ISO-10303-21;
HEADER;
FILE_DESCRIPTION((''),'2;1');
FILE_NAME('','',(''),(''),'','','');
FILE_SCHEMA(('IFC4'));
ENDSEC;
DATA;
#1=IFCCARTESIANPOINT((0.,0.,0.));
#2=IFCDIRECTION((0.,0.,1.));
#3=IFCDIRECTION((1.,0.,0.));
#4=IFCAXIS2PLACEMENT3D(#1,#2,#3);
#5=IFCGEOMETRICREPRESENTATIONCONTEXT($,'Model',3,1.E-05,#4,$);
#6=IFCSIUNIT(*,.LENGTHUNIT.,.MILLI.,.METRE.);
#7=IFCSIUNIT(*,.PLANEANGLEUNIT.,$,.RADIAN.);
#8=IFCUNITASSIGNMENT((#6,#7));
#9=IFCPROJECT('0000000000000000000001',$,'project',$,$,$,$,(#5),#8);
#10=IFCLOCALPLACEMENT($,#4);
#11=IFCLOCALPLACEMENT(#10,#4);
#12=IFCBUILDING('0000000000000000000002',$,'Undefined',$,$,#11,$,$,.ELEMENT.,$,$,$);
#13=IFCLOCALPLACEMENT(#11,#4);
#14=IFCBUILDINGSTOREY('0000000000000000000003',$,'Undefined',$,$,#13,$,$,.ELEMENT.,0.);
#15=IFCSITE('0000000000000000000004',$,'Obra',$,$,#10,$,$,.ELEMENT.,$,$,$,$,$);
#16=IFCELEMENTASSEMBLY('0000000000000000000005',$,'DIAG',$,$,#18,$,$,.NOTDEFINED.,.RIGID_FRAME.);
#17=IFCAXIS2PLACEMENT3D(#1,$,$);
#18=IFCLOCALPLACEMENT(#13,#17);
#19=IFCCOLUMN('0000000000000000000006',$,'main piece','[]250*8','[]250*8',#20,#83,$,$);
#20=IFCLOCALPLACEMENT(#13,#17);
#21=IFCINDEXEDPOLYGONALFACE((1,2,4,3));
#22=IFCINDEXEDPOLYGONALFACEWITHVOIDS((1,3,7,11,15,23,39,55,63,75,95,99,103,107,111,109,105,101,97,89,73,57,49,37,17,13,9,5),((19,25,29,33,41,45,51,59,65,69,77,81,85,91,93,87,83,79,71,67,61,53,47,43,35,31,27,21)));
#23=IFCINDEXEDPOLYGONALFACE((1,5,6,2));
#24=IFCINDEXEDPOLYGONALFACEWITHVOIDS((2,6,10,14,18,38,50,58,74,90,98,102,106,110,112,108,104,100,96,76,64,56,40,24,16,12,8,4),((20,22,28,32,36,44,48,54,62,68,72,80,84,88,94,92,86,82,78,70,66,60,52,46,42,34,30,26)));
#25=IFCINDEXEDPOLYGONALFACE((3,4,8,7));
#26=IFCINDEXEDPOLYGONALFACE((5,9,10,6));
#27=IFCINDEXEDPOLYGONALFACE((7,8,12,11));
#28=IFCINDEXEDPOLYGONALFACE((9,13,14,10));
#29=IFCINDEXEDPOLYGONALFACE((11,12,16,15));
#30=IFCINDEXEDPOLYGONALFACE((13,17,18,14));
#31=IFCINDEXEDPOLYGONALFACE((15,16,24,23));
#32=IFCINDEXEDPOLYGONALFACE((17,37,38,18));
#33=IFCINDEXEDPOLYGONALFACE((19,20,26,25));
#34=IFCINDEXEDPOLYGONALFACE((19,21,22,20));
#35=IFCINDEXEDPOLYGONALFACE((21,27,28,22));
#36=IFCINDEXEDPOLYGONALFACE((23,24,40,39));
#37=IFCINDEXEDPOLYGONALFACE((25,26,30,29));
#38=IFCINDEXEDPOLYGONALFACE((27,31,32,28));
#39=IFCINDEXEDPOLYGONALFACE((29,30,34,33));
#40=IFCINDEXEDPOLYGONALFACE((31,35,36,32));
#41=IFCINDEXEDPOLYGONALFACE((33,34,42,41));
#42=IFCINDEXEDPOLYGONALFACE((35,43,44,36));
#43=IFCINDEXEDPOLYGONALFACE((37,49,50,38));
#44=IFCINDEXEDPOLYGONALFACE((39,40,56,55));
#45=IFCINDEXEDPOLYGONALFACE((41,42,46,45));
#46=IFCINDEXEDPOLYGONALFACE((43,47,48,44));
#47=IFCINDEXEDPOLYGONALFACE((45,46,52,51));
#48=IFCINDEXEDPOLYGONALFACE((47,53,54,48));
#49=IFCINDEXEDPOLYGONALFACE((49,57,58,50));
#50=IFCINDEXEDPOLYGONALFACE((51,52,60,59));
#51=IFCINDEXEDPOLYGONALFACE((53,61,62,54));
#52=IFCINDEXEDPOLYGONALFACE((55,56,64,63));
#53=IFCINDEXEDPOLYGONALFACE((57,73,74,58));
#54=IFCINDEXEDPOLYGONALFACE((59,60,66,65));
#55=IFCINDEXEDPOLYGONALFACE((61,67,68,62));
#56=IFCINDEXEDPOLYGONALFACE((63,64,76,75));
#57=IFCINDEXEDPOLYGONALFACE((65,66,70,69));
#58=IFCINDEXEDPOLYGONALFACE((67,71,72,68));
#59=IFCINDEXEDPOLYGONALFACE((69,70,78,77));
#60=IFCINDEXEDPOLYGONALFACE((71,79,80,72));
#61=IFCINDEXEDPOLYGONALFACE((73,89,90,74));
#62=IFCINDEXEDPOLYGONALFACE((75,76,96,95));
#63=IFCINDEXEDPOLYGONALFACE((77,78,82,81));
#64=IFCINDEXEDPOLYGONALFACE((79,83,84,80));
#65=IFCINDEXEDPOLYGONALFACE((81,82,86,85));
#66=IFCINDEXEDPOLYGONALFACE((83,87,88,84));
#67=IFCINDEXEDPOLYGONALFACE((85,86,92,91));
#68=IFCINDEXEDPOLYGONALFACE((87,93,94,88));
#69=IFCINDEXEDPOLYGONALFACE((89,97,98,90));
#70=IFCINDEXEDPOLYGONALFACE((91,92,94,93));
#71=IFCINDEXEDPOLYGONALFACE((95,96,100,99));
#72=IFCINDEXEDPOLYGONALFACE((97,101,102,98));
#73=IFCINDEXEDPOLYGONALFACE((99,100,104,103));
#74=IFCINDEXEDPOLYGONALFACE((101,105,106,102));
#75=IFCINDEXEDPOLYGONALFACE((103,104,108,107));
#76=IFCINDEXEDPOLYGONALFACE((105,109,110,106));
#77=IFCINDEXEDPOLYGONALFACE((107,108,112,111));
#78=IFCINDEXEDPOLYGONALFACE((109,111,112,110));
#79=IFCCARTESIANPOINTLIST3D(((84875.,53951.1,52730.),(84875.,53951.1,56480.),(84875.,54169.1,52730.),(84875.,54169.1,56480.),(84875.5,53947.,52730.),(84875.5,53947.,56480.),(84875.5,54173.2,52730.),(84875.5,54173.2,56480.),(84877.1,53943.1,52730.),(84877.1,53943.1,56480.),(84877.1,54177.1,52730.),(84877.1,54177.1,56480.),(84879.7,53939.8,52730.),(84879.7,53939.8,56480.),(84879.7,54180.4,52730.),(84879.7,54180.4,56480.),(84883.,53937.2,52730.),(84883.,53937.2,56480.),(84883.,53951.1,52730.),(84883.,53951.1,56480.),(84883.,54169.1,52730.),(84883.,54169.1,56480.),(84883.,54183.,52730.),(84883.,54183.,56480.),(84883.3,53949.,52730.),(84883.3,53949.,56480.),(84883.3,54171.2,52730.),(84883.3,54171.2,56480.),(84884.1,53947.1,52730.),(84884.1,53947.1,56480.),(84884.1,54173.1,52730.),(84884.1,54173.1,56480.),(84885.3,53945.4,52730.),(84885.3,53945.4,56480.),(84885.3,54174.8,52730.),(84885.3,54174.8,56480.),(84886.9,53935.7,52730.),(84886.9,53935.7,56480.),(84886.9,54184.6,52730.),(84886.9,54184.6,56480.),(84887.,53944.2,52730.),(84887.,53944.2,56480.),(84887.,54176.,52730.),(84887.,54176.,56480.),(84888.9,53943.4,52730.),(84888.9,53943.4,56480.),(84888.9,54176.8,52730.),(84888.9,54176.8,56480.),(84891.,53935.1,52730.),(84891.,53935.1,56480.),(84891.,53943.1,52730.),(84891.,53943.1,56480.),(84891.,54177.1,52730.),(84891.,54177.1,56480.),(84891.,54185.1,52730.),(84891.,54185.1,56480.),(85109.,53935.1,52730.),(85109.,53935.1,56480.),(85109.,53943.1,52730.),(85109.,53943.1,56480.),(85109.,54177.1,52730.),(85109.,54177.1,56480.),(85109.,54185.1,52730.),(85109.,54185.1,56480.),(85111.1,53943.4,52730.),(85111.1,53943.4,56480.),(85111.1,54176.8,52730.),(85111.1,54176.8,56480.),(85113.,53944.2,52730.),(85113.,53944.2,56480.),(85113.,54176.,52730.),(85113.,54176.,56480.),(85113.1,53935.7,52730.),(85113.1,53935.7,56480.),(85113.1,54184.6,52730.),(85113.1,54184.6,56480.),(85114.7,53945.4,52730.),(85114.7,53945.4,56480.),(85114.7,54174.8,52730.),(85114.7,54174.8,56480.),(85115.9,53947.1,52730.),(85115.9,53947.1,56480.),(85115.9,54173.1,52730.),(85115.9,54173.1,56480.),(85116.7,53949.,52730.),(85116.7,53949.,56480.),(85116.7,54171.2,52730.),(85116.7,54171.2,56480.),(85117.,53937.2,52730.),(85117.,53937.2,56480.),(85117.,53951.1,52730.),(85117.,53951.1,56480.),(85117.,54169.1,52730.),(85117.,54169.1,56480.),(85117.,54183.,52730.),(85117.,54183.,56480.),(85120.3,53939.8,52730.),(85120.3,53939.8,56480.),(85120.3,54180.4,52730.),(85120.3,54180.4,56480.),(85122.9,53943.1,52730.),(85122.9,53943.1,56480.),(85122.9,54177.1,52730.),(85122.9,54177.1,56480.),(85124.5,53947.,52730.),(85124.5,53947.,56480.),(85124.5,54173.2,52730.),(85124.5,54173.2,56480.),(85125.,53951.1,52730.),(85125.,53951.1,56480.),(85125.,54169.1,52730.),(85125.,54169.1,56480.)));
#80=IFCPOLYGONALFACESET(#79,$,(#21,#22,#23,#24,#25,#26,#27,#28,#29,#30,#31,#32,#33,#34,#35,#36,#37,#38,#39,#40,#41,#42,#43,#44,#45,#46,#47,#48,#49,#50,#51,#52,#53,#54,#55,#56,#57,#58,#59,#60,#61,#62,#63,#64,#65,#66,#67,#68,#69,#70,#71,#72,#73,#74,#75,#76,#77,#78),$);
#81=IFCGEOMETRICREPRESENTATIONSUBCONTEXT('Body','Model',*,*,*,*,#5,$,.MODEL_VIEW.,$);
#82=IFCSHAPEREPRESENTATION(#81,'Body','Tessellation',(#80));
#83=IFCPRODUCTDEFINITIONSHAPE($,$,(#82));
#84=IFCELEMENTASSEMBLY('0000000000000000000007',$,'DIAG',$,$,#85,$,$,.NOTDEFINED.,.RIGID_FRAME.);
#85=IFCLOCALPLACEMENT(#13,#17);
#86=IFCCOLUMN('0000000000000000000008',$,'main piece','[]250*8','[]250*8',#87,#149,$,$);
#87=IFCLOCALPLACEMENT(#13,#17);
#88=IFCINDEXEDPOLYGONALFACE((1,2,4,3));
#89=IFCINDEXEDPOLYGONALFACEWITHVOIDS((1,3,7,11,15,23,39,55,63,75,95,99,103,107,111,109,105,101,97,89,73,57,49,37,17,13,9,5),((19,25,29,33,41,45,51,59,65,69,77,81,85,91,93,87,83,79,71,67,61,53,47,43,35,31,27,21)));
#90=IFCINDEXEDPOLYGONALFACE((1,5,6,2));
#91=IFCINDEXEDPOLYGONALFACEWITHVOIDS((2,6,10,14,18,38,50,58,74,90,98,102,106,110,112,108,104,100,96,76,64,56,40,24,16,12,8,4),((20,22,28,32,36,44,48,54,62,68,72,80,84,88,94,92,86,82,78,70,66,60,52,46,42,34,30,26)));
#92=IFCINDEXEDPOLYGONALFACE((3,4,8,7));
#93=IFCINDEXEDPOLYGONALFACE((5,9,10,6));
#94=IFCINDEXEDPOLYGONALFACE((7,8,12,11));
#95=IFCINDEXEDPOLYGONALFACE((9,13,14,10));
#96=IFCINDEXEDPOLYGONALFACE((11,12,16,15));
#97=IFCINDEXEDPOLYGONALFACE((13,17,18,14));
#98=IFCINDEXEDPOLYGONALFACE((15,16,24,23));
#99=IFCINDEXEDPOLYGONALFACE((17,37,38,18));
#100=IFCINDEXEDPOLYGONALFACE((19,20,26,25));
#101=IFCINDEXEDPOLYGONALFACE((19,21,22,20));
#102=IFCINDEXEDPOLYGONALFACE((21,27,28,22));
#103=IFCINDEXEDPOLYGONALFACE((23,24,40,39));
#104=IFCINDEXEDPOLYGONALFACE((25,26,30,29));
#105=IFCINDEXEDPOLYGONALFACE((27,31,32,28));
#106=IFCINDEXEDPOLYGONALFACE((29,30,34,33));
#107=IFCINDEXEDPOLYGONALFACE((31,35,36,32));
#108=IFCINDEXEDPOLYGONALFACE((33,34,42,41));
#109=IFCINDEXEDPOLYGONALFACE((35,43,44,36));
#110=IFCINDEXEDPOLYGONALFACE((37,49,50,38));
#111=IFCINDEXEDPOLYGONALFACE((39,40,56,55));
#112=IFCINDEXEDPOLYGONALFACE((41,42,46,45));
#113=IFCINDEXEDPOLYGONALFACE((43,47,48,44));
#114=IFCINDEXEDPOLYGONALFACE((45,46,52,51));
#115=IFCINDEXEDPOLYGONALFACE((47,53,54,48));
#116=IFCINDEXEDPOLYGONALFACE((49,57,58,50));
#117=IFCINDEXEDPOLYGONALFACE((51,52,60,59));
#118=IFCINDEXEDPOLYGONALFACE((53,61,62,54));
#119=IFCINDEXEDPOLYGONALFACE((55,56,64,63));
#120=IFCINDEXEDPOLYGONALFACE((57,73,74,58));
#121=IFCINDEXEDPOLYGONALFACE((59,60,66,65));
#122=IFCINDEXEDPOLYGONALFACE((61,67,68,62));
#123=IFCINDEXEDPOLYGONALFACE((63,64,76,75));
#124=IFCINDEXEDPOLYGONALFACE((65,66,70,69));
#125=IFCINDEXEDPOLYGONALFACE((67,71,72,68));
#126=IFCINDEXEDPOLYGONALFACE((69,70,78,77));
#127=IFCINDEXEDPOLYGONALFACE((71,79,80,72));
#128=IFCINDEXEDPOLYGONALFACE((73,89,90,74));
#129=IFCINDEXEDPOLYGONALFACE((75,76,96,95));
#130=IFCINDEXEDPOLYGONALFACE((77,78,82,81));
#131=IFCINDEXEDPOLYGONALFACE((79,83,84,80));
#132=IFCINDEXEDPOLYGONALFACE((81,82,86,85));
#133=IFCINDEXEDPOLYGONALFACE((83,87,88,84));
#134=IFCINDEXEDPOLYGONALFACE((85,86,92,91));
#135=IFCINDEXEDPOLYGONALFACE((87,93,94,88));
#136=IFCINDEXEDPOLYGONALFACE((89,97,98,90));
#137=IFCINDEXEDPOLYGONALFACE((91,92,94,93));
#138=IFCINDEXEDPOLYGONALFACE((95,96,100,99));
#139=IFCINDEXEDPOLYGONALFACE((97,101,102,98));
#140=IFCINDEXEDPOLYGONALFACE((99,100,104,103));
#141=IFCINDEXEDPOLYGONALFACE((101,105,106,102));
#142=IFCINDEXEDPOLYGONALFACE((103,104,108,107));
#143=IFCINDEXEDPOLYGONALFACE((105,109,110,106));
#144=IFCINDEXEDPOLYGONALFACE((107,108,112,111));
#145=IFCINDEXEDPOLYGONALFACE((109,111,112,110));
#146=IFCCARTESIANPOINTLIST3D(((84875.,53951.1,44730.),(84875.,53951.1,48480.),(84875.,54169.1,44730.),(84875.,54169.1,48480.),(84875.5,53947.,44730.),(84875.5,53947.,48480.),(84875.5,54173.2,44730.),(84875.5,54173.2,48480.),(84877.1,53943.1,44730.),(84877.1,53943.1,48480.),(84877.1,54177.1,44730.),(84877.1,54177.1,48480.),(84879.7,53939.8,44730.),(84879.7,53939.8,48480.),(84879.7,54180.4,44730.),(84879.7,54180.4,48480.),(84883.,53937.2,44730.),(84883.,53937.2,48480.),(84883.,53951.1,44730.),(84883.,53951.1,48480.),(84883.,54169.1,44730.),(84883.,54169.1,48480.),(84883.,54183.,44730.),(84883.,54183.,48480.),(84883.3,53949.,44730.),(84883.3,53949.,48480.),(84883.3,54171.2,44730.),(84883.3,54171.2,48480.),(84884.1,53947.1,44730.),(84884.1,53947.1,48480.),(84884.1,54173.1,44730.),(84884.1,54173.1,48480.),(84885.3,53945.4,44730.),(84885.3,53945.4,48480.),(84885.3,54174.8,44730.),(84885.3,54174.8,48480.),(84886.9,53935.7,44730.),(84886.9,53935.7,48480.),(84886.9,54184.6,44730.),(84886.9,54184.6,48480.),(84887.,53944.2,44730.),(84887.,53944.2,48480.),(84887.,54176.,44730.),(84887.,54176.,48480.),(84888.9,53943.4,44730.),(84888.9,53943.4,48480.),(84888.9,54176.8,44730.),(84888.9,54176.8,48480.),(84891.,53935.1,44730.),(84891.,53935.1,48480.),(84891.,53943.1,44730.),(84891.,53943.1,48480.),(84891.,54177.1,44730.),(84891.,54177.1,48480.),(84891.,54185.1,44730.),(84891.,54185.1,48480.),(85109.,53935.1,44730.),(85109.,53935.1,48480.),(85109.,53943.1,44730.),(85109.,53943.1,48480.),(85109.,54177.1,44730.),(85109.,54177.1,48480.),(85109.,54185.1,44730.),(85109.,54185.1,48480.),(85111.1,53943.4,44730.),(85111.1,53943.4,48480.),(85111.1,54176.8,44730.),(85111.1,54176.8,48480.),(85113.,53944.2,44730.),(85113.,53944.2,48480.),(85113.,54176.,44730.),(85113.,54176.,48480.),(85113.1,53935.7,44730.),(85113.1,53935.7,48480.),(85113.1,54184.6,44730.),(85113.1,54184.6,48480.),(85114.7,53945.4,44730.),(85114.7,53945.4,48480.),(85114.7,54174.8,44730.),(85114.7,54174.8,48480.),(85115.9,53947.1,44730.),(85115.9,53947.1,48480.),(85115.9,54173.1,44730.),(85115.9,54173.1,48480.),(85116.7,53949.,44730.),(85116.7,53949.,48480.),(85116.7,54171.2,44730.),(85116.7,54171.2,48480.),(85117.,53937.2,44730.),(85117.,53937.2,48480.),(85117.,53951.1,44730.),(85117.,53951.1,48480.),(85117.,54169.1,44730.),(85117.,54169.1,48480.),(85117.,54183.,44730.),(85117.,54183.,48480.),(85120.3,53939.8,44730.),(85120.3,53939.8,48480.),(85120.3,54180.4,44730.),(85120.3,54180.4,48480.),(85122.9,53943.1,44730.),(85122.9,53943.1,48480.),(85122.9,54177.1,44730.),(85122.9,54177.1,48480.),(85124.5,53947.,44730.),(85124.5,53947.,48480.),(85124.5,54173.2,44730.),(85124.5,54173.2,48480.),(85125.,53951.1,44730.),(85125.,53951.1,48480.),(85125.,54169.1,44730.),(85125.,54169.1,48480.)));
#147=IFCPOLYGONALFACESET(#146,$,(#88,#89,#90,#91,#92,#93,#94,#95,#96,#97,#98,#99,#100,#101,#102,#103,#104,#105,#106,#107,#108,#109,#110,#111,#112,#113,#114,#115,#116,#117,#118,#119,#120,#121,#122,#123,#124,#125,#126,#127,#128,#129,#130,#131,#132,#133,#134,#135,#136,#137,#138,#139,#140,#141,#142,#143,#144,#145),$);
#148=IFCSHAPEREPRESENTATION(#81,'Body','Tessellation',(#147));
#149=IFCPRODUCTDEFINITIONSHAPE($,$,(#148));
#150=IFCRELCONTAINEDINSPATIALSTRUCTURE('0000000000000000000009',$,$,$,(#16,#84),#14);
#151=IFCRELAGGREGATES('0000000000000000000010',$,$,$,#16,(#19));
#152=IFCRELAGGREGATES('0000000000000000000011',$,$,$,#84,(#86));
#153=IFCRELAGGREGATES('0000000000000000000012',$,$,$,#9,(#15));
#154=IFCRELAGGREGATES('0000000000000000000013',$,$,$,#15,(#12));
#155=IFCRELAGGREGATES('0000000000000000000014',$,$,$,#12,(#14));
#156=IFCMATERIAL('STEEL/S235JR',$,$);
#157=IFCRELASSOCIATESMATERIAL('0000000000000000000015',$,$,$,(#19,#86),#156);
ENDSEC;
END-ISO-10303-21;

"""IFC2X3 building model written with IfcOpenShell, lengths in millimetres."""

from ifc_helpers import new_model, si_unit, frame, origin_with_axes, origin_2d_with_axis, place, context, subcontext, project, spatial, hollow_rectangle, extrude, material, element, aggregate, save


model = new_model("IFC2X3")

# Units and contexts
model_context = context("Model", 3, precision=1e-05, world=origin_with_axes())
body_context = subcontext(model_context, "Body", "Model", "MODEL_VIEW")
ifc_project = project(units=[si_unit("LENGTHUNIT", "METRE", prefix="MILLI"), si_unit("PLANEANGLEUNIT", "RADIAN")], contexts=[model_context])

# Site, building, storey
site_placement = place(None, origin_with_axes())
site = spatial("IfcSite", under=ifc_project, at=site_placement, Name="Obra", CompositionType="ELEMENT")
building_placement = place(site_placement, origin_with_axes())
building = spatial("IfcBuilding", under=site, at=building_placement, Name="Undefined", CompositionType="ELEMENT")
storey_placement = place(building_placement, origin_with_axes())
storey = spatial("IfcBuildingStorey", under=building, at=storey_placement, Name="Undefined", CompositionType="ELEMENT", Elevation=0.0)

# Element assemblies, columns
ifc_material = material(Name="STEEL/S235JR")
assembly_1_placement = place(storey_placement, origin_with_axes())
assembly_1 = element("IfcElementAssembly", 1, at=assembly_1_placement, inside=storey, Name="DIAG", AssemblyPlace="NOTDEFINED", PredefinedType="RIGID_FRAME")
column_1_placement = place(assembly_1_placement, frame((85000.0, 54060.1, 52730.0), z_axis=(0.0, 0.0, 1.0), x_axis=(-1.0, 0.0, 0.0)))
column_1 = element("IfcColumn", 2, at=column_1_placement, material=ifc_material, Name="main piece", Description="[]250*8", ObjectType="[]250*8", context=body_context, shape_type="SweptSolid", body=[
    extrude(hollow_rectangle(XDim=250.0, YDim=250.0, WallThickness=8.0, InnerFilletRadius=8.0, OuterFilletRadius=16.0, at=origin_2d_with_axis()), frame((0.0, 0.0, 3750.0), z_axis=(0.0, 0.0, -1.0), x_axis=(0.0, 1.0, 0.0)), (0.0, 0.0, 1.0), 3750.0),
])
aggregate(assembly_1, [column_1])
assembly_2_placement = place(storey_placement, origin_with_axes())
assembly_2 = element("IfcElementAssembly", 3, at=assembly_2_placement, inside=storey, Name="DIAG", AssemblyPlace="NOTDEFINED", PredefinedType="RIGID_FRAME")
column_2_placement = place(assembly_2_placement, frame((85000.0, 54060.1, 44730.0), z_axis=(0.0, 0.0, 1.0), x_axis=(-1.0, 0.0, 0.0)))
column_2 = element("IfcColumn", 4, at=column_2_placement, material=ifc_material, Name="main piece", Description="[]250*8", ObjectType="[]250*8", context=body_context, shape_type="SweptSolid", body=[
    extrude(hollow_rectangle(XDim=250.0, YDim=250.0, WallThickness=8.0, InnerFilletRadius=8.0, OuterFilletRadius=16.0, at=origin_2d_with_axis()), frame((0.0, 0.0, 3750.0), z_axis=(0.0, 0.0, -1.0), x_axis=(0.0, 1.0, 0.0)), (0.0, 0.0, 1.0), 3750.0),
])
aggregate(assembly_2, [column_2])

save(model, "model.ifc")
